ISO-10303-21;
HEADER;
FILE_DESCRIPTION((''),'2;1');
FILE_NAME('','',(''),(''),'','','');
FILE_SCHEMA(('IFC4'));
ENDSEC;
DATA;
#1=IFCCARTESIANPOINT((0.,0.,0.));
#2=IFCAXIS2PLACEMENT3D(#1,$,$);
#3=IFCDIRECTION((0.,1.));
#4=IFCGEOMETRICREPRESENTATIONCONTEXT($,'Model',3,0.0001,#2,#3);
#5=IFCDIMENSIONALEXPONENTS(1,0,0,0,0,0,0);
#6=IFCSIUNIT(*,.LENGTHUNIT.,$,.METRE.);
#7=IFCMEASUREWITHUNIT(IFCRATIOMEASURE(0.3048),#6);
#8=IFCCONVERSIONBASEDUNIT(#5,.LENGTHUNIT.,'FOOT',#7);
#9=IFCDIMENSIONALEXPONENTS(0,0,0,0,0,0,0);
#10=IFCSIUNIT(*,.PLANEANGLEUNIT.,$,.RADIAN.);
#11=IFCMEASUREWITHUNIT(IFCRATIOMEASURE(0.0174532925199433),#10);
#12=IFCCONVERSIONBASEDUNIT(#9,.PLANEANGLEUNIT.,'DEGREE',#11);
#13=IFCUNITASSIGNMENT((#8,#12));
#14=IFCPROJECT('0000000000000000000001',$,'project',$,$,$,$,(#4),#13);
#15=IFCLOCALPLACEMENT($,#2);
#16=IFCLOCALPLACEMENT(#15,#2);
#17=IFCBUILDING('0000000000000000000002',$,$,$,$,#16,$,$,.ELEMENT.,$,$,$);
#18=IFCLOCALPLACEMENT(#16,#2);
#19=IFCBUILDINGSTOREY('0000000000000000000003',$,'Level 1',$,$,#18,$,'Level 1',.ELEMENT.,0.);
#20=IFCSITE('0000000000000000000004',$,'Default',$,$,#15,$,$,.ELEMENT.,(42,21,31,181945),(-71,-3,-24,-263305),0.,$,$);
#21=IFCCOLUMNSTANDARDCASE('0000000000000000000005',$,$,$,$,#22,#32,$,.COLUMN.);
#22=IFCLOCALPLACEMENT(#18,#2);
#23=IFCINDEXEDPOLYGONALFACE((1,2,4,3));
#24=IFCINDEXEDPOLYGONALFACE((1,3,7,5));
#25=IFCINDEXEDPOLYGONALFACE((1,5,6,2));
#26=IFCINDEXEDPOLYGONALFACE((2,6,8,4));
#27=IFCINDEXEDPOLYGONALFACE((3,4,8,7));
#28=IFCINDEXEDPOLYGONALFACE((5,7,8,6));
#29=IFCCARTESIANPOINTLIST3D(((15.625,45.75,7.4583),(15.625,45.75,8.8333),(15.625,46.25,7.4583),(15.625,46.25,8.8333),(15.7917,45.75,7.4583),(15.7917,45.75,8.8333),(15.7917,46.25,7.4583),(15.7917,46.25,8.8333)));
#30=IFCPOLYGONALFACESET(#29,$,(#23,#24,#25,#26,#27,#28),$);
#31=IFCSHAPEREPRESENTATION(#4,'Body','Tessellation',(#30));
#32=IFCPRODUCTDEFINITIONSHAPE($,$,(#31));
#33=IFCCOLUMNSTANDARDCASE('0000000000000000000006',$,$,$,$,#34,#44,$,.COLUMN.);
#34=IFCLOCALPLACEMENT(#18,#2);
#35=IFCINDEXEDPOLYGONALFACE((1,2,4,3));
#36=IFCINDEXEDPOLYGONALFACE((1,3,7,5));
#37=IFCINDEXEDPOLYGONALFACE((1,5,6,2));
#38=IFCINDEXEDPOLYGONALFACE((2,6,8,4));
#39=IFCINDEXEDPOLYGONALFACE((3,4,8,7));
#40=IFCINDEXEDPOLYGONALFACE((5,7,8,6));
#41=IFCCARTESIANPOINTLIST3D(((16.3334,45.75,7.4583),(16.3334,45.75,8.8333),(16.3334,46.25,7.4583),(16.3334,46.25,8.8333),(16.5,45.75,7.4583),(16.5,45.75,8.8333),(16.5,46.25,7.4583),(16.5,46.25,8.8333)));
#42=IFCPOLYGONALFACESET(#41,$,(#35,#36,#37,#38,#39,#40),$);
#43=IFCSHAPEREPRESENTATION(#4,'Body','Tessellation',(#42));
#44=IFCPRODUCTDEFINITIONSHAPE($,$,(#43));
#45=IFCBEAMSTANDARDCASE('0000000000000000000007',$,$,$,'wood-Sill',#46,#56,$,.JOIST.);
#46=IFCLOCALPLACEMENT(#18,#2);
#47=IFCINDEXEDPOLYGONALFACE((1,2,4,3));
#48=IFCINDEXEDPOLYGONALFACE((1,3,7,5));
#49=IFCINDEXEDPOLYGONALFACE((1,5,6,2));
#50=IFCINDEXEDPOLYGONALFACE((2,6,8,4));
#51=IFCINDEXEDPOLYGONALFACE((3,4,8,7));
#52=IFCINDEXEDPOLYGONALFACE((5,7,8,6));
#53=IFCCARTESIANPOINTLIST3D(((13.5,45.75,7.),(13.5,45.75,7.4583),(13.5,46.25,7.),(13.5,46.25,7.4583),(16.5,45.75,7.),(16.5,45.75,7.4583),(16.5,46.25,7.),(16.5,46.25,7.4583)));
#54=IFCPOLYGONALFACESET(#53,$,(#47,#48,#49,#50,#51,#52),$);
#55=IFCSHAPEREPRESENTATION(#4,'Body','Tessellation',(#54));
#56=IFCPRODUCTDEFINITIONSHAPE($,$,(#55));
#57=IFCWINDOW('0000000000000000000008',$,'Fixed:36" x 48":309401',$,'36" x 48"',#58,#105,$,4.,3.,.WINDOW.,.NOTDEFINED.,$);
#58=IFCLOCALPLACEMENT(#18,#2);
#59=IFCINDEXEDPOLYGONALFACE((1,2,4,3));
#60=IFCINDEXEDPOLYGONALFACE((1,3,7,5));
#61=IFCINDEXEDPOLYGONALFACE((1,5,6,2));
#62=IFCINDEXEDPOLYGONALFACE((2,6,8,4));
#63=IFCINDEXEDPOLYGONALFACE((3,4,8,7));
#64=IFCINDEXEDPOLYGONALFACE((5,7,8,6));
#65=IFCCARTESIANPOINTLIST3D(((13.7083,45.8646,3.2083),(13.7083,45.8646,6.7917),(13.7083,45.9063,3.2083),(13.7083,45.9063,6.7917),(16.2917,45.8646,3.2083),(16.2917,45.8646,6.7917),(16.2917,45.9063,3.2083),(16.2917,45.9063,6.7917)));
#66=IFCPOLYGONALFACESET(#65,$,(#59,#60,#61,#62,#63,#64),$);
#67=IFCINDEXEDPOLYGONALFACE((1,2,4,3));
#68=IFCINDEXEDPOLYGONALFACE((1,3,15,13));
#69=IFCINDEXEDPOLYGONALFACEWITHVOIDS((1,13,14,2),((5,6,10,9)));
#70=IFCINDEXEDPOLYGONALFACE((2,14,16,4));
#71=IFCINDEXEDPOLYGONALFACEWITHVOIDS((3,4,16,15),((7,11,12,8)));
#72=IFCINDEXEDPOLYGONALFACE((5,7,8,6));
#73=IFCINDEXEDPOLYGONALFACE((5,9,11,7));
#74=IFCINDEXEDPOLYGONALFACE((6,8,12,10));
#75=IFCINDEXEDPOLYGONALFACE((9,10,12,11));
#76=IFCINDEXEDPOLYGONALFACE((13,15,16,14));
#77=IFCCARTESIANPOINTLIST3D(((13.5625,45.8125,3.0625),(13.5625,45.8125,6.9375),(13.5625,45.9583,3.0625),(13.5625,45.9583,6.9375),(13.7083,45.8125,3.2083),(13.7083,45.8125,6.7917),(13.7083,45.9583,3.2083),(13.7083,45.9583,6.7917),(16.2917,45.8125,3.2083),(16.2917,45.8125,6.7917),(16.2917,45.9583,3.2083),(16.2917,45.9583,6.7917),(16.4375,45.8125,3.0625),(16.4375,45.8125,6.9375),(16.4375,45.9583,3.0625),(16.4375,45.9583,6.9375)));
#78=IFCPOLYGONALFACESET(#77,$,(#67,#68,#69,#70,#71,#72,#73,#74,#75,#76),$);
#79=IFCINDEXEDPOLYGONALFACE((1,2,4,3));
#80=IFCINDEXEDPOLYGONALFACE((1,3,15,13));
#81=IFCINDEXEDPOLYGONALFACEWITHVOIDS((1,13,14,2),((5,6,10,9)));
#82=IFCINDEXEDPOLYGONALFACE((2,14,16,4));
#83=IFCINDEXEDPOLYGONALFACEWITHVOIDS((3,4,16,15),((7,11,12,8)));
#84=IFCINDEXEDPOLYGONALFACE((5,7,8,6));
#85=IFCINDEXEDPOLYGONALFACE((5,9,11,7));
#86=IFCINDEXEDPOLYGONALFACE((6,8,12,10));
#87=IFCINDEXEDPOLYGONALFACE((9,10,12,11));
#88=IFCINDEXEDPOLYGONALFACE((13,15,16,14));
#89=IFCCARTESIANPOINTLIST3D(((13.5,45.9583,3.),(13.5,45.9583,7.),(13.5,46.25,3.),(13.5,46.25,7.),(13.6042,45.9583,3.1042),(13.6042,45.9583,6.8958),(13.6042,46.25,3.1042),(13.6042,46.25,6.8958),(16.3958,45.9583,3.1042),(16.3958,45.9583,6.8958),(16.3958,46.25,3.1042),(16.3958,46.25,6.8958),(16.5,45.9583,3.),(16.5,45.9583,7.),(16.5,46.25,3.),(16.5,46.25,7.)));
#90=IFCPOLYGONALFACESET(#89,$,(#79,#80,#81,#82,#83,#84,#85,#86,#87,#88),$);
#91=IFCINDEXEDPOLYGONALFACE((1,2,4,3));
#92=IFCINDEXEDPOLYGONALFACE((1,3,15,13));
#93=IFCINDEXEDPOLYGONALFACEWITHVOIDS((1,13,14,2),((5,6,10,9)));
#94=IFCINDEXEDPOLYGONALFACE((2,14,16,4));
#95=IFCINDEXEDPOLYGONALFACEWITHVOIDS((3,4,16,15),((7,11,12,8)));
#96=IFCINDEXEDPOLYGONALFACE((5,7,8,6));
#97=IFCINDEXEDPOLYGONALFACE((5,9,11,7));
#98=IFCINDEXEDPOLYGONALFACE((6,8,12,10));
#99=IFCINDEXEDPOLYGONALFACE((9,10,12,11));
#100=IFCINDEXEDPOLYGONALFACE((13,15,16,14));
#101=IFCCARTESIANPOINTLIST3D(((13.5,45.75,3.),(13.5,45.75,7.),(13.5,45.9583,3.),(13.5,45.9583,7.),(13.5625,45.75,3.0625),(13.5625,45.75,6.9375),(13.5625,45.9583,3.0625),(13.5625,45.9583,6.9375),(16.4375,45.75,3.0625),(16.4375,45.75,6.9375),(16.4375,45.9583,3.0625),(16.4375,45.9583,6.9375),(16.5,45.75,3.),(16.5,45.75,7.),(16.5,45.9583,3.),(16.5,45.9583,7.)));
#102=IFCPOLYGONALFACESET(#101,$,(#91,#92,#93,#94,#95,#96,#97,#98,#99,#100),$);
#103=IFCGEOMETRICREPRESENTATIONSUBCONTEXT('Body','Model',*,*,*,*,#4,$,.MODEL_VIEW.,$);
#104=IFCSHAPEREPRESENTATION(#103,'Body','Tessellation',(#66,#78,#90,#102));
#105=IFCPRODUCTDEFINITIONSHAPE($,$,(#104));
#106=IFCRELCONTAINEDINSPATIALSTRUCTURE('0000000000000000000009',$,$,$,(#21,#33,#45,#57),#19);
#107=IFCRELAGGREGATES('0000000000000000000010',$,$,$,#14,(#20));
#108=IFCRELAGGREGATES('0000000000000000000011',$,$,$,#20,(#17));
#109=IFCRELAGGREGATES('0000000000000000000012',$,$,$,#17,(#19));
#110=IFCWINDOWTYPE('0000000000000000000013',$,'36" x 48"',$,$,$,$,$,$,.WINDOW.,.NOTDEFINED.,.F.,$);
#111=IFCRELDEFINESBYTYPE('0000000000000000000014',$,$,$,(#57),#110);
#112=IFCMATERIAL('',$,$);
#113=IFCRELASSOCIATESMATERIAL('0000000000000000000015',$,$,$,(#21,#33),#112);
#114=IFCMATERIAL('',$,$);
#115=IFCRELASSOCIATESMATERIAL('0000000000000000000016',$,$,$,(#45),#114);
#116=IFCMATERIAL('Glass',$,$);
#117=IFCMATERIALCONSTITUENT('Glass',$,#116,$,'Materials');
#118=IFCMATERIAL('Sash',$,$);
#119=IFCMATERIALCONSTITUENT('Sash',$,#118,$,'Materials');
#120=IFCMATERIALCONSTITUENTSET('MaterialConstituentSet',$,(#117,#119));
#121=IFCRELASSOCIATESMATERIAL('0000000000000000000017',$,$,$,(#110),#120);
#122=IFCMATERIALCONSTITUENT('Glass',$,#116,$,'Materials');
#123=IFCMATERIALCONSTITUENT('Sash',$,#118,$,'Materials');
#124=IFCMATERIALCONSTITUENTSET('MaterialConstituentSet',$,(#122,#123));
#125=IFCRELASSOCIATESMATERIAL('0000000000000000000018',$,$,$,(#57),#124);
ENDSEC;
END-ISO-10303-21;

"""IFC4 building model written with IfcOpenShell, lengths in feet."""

from ifc_helpers import new_model, entity, si_unit, converted_unit, direction, frame, frame_2d, origin, place, context, subcontext, project, spatial, polyline, rectangle, outline, extrude, source, transform, mapped, material, constituent, constituent_set, type_object, type_shapes, element, save


model = new_model("IFC4")

# Units and contexts
model_context = context("Model", 3, precision=0.0001, world=origin(), true_north=direction((0.0, 1.0)))
body_context = subcontext(model_context, "Body", "Model", "MODEL_VIEW")
ifc_project = project(units=[converted_unit("LENGTHUNIT", "FOOT", entity("IfcRatioMeasure", 0.3048), si_unit("LENGTHUNIT", "METRE"), dimensions=[1, 0, 0, 0, 0, 0, 0]), converted_unit("PLANEANGLEUNIT", "DEGREE", entity("IfcRatioMeasure", 0.0174532925199433), si_unit("PLANEANGLEUNIT", "RADIAN"), dimensions=[0, 0, 0, 0, 0, 0, 0])], contexts=[model_context])

# Site, building, storey
site_placement = place(None, origin())
site = spatial("IfcSite", under=ifc_project, at=site_placement, Name="Default", CompositionType="ELEMENT", RefLatitude=(42, 21, 31, 181945), RefLongitude=(-71, -3, -24, -263305), RefElevation=0.0)
building_placement = place(site_placement, origin())
building = spatial("IfcBuilding", under=site, at=building_placement, CompositionType="ELEMENT")
storey_placement = place(building_placement, origin())
storey = spatial("IfcBuildingStorey", under=building, at=storey_placement, Name="Level 1", LongName="Level 1", CompositionType="ELEMENT", Elevation=0.0)

# Columns
placement_1 = place(storey_placement, frame((-0.25, 46.0, 0.0)))
ifc_material_1 = material(Name="")
for number, where, z_axis, x_axis in (
    (1, (15.9584, 0.0, 7.4583), (0.0, 0.0, 1.0), (1.0, 0.0, 0.0)),
    (2, (16.6667, 0.0, 7.4583), (0.0, 0.0, 1.0), (1.0, 0.0, 0.0)),
):
    element("IfcColumnStandardCase", number, at=place(placement_1, frame(where, z_axis=z_axis, x_axis=x_axis)), inside=storey, material=ifc_material_1, PredefinedType="COLUMN", context=model_context, shape_type="SweptSolid", body=[
        extrude(rectangle(XDim=0.1667, YDim=0.5), origin(), (0.0, 0.0, 1.0), 1.375),
    ])

# Beam
ifc_material_2 = material(Name="")
beam_placement = place(placement_1, frame((15.25, 0.0, 7.0), z_axis=(0.0, 0.0, 1.0), x_axis=(-1.0, 0.0, 0.0)))
element("IfcBeamStandardCase", 3, at=beam_placement, inside=storey, material=ifc_material_2, ObjectType="wood-Sill", PredefinedType="JOIST", context=model_context, shape_type="SweptSolid", body=[
    extrude(rectangle(XDim=3.0, YDim=0.5), origin(), (0.0, 0.0, 1.0), 0.4583),
])

# Window
ifc_material_3 = material(Name="Glass")
ifc_constituent_1 = constituent(ifc_material_3, Name="Glass", Category="Materials")
ifc_material_4 = material(Name="Sash")
ifc_constituent_2 = constituent(ifc_material_4, Name="Sash", Category="Materials")
ifc_constituent_set_1 = constituent_set(constituents=[ifc_constituent_1, ifc_constituent_2], Name="MaterialConstituentSet")
ifc_constituent_3 = constituent(ifc_material_3, Name="Glass", Category="Materials")
ifc_constituent_4 = constituent(ifc_material_4, Name="Sash", Category="Materials")
ifc_constituent_set_2 = constituent_set(constituents=[ifc_constituent_3, ifc_constituent_4], Name="MaterialConstituentSet")
window_type = type_object("IfcWindowType", Name="36\" x 48\"", ParameterTakesPrecedence=False, PartitioningType="NOTDEFINED", PredefinedType="WINDOW", material=ifc_constituent_set_2)
shared_shape = source(origin(), body_context, "Body", "SweptSolid", [
    extrude(rectangle(XDim=0.0417, YDim=2.5833, at=frame_2d((0.0, 0.0), x_axis=(1.0, 0.0))), frame((1.5, 0.3646, 0.2083), z_axis=(0.0, 0.0, 1.0), x_axis=(0.0, 1.0, 0.0)), (0.0, 0.0, 1.0), 3.5833),
    extrude(outline(polyline([(-1.4375, -1.9375), (1.4375, -1.9375), (1.4375, 1.9375), (-1.4375, 1.9375), (-1.4375, -1.9375)]), holes=[polyline([(-1.2917, -1.7917), (-1.2917, 1.7917), (1.2917, 1.7917), (1.2917, -1.7917), (-1.2917, -1.7917)])]), frame((1.5, 0.2917, 2.0), z_axis=(0.0, 1.0, 0.0), x_axis=(1.0, 0.0, 0.0)), (0.0, 0.0, 1.0), 0.1458),
    extrude(outline(polyline([(-1.5, -2.0), (1.5, -2.0), (1.5, 2.0), (-1.5, 2.0), (-1.5, -2.0)]), holes=[polyline([(-1.3958, -1.8958), (-1.3958, 1.8958), (1.3958, 1.8958), (1.3958, -1.8958), (-1.3958, -1.8958)])]), frame((1.5, 0.0, 2.0), z_axis=(0.0, 1.0, 0.0), x_axis=(1.0, 0.0, 0.0)), (0.0, 0.0, 1.0), 0.2917),
    extrude(outline(polyline([(-2.0, -1.5), (2.0, -1.5), (2.0, 1.5), (-2.0, 1.5), (-2.0, -1.5)]), holes=[polyline([(-1.9375, -1.4375), (-1.9375, 1.4375), (1.9375, 1.4375), (1.9375, -1.4375), (-1.9375, -1.4375)])]), frame((1.5, 0.2917, 2.0), z_axis=(0.0, 1.0, 0.0), x_axis=(0.0, 0.0, -1.0)), (0.0, 0.0, 1.0), 0.2083),
])
type_shapes(window_type, [shared_shape])
placement_2 = place(placement_1, frame((16.75, 0.25, 3.0)))
window_placement = place(placement_2, frame((0.0, 0.0, 0.0), z_axis=(0.0, 0.0, 1.0), x_axis=(-1.0, 0.0, 0.0)))
element("IfcWindow", 4, at=window_placement, inside=storey, type_object=window_type, material=ifc_constituent_set_1, Name="Fixed:36\" x 48\":309401", ObjectType="36\" x 48\"", OverallHeight=4.0, OverallWidth=3.0, PartitioningType="NOTDEFINED", PredefinedType="WINDOW", context=body_context, shape_type="MappedRepresentation", body=[
    mapped(shared_shape, transform((0.0, 0.0, 0.0), scale=1.0)),
])

save(model, "model.ifc")
